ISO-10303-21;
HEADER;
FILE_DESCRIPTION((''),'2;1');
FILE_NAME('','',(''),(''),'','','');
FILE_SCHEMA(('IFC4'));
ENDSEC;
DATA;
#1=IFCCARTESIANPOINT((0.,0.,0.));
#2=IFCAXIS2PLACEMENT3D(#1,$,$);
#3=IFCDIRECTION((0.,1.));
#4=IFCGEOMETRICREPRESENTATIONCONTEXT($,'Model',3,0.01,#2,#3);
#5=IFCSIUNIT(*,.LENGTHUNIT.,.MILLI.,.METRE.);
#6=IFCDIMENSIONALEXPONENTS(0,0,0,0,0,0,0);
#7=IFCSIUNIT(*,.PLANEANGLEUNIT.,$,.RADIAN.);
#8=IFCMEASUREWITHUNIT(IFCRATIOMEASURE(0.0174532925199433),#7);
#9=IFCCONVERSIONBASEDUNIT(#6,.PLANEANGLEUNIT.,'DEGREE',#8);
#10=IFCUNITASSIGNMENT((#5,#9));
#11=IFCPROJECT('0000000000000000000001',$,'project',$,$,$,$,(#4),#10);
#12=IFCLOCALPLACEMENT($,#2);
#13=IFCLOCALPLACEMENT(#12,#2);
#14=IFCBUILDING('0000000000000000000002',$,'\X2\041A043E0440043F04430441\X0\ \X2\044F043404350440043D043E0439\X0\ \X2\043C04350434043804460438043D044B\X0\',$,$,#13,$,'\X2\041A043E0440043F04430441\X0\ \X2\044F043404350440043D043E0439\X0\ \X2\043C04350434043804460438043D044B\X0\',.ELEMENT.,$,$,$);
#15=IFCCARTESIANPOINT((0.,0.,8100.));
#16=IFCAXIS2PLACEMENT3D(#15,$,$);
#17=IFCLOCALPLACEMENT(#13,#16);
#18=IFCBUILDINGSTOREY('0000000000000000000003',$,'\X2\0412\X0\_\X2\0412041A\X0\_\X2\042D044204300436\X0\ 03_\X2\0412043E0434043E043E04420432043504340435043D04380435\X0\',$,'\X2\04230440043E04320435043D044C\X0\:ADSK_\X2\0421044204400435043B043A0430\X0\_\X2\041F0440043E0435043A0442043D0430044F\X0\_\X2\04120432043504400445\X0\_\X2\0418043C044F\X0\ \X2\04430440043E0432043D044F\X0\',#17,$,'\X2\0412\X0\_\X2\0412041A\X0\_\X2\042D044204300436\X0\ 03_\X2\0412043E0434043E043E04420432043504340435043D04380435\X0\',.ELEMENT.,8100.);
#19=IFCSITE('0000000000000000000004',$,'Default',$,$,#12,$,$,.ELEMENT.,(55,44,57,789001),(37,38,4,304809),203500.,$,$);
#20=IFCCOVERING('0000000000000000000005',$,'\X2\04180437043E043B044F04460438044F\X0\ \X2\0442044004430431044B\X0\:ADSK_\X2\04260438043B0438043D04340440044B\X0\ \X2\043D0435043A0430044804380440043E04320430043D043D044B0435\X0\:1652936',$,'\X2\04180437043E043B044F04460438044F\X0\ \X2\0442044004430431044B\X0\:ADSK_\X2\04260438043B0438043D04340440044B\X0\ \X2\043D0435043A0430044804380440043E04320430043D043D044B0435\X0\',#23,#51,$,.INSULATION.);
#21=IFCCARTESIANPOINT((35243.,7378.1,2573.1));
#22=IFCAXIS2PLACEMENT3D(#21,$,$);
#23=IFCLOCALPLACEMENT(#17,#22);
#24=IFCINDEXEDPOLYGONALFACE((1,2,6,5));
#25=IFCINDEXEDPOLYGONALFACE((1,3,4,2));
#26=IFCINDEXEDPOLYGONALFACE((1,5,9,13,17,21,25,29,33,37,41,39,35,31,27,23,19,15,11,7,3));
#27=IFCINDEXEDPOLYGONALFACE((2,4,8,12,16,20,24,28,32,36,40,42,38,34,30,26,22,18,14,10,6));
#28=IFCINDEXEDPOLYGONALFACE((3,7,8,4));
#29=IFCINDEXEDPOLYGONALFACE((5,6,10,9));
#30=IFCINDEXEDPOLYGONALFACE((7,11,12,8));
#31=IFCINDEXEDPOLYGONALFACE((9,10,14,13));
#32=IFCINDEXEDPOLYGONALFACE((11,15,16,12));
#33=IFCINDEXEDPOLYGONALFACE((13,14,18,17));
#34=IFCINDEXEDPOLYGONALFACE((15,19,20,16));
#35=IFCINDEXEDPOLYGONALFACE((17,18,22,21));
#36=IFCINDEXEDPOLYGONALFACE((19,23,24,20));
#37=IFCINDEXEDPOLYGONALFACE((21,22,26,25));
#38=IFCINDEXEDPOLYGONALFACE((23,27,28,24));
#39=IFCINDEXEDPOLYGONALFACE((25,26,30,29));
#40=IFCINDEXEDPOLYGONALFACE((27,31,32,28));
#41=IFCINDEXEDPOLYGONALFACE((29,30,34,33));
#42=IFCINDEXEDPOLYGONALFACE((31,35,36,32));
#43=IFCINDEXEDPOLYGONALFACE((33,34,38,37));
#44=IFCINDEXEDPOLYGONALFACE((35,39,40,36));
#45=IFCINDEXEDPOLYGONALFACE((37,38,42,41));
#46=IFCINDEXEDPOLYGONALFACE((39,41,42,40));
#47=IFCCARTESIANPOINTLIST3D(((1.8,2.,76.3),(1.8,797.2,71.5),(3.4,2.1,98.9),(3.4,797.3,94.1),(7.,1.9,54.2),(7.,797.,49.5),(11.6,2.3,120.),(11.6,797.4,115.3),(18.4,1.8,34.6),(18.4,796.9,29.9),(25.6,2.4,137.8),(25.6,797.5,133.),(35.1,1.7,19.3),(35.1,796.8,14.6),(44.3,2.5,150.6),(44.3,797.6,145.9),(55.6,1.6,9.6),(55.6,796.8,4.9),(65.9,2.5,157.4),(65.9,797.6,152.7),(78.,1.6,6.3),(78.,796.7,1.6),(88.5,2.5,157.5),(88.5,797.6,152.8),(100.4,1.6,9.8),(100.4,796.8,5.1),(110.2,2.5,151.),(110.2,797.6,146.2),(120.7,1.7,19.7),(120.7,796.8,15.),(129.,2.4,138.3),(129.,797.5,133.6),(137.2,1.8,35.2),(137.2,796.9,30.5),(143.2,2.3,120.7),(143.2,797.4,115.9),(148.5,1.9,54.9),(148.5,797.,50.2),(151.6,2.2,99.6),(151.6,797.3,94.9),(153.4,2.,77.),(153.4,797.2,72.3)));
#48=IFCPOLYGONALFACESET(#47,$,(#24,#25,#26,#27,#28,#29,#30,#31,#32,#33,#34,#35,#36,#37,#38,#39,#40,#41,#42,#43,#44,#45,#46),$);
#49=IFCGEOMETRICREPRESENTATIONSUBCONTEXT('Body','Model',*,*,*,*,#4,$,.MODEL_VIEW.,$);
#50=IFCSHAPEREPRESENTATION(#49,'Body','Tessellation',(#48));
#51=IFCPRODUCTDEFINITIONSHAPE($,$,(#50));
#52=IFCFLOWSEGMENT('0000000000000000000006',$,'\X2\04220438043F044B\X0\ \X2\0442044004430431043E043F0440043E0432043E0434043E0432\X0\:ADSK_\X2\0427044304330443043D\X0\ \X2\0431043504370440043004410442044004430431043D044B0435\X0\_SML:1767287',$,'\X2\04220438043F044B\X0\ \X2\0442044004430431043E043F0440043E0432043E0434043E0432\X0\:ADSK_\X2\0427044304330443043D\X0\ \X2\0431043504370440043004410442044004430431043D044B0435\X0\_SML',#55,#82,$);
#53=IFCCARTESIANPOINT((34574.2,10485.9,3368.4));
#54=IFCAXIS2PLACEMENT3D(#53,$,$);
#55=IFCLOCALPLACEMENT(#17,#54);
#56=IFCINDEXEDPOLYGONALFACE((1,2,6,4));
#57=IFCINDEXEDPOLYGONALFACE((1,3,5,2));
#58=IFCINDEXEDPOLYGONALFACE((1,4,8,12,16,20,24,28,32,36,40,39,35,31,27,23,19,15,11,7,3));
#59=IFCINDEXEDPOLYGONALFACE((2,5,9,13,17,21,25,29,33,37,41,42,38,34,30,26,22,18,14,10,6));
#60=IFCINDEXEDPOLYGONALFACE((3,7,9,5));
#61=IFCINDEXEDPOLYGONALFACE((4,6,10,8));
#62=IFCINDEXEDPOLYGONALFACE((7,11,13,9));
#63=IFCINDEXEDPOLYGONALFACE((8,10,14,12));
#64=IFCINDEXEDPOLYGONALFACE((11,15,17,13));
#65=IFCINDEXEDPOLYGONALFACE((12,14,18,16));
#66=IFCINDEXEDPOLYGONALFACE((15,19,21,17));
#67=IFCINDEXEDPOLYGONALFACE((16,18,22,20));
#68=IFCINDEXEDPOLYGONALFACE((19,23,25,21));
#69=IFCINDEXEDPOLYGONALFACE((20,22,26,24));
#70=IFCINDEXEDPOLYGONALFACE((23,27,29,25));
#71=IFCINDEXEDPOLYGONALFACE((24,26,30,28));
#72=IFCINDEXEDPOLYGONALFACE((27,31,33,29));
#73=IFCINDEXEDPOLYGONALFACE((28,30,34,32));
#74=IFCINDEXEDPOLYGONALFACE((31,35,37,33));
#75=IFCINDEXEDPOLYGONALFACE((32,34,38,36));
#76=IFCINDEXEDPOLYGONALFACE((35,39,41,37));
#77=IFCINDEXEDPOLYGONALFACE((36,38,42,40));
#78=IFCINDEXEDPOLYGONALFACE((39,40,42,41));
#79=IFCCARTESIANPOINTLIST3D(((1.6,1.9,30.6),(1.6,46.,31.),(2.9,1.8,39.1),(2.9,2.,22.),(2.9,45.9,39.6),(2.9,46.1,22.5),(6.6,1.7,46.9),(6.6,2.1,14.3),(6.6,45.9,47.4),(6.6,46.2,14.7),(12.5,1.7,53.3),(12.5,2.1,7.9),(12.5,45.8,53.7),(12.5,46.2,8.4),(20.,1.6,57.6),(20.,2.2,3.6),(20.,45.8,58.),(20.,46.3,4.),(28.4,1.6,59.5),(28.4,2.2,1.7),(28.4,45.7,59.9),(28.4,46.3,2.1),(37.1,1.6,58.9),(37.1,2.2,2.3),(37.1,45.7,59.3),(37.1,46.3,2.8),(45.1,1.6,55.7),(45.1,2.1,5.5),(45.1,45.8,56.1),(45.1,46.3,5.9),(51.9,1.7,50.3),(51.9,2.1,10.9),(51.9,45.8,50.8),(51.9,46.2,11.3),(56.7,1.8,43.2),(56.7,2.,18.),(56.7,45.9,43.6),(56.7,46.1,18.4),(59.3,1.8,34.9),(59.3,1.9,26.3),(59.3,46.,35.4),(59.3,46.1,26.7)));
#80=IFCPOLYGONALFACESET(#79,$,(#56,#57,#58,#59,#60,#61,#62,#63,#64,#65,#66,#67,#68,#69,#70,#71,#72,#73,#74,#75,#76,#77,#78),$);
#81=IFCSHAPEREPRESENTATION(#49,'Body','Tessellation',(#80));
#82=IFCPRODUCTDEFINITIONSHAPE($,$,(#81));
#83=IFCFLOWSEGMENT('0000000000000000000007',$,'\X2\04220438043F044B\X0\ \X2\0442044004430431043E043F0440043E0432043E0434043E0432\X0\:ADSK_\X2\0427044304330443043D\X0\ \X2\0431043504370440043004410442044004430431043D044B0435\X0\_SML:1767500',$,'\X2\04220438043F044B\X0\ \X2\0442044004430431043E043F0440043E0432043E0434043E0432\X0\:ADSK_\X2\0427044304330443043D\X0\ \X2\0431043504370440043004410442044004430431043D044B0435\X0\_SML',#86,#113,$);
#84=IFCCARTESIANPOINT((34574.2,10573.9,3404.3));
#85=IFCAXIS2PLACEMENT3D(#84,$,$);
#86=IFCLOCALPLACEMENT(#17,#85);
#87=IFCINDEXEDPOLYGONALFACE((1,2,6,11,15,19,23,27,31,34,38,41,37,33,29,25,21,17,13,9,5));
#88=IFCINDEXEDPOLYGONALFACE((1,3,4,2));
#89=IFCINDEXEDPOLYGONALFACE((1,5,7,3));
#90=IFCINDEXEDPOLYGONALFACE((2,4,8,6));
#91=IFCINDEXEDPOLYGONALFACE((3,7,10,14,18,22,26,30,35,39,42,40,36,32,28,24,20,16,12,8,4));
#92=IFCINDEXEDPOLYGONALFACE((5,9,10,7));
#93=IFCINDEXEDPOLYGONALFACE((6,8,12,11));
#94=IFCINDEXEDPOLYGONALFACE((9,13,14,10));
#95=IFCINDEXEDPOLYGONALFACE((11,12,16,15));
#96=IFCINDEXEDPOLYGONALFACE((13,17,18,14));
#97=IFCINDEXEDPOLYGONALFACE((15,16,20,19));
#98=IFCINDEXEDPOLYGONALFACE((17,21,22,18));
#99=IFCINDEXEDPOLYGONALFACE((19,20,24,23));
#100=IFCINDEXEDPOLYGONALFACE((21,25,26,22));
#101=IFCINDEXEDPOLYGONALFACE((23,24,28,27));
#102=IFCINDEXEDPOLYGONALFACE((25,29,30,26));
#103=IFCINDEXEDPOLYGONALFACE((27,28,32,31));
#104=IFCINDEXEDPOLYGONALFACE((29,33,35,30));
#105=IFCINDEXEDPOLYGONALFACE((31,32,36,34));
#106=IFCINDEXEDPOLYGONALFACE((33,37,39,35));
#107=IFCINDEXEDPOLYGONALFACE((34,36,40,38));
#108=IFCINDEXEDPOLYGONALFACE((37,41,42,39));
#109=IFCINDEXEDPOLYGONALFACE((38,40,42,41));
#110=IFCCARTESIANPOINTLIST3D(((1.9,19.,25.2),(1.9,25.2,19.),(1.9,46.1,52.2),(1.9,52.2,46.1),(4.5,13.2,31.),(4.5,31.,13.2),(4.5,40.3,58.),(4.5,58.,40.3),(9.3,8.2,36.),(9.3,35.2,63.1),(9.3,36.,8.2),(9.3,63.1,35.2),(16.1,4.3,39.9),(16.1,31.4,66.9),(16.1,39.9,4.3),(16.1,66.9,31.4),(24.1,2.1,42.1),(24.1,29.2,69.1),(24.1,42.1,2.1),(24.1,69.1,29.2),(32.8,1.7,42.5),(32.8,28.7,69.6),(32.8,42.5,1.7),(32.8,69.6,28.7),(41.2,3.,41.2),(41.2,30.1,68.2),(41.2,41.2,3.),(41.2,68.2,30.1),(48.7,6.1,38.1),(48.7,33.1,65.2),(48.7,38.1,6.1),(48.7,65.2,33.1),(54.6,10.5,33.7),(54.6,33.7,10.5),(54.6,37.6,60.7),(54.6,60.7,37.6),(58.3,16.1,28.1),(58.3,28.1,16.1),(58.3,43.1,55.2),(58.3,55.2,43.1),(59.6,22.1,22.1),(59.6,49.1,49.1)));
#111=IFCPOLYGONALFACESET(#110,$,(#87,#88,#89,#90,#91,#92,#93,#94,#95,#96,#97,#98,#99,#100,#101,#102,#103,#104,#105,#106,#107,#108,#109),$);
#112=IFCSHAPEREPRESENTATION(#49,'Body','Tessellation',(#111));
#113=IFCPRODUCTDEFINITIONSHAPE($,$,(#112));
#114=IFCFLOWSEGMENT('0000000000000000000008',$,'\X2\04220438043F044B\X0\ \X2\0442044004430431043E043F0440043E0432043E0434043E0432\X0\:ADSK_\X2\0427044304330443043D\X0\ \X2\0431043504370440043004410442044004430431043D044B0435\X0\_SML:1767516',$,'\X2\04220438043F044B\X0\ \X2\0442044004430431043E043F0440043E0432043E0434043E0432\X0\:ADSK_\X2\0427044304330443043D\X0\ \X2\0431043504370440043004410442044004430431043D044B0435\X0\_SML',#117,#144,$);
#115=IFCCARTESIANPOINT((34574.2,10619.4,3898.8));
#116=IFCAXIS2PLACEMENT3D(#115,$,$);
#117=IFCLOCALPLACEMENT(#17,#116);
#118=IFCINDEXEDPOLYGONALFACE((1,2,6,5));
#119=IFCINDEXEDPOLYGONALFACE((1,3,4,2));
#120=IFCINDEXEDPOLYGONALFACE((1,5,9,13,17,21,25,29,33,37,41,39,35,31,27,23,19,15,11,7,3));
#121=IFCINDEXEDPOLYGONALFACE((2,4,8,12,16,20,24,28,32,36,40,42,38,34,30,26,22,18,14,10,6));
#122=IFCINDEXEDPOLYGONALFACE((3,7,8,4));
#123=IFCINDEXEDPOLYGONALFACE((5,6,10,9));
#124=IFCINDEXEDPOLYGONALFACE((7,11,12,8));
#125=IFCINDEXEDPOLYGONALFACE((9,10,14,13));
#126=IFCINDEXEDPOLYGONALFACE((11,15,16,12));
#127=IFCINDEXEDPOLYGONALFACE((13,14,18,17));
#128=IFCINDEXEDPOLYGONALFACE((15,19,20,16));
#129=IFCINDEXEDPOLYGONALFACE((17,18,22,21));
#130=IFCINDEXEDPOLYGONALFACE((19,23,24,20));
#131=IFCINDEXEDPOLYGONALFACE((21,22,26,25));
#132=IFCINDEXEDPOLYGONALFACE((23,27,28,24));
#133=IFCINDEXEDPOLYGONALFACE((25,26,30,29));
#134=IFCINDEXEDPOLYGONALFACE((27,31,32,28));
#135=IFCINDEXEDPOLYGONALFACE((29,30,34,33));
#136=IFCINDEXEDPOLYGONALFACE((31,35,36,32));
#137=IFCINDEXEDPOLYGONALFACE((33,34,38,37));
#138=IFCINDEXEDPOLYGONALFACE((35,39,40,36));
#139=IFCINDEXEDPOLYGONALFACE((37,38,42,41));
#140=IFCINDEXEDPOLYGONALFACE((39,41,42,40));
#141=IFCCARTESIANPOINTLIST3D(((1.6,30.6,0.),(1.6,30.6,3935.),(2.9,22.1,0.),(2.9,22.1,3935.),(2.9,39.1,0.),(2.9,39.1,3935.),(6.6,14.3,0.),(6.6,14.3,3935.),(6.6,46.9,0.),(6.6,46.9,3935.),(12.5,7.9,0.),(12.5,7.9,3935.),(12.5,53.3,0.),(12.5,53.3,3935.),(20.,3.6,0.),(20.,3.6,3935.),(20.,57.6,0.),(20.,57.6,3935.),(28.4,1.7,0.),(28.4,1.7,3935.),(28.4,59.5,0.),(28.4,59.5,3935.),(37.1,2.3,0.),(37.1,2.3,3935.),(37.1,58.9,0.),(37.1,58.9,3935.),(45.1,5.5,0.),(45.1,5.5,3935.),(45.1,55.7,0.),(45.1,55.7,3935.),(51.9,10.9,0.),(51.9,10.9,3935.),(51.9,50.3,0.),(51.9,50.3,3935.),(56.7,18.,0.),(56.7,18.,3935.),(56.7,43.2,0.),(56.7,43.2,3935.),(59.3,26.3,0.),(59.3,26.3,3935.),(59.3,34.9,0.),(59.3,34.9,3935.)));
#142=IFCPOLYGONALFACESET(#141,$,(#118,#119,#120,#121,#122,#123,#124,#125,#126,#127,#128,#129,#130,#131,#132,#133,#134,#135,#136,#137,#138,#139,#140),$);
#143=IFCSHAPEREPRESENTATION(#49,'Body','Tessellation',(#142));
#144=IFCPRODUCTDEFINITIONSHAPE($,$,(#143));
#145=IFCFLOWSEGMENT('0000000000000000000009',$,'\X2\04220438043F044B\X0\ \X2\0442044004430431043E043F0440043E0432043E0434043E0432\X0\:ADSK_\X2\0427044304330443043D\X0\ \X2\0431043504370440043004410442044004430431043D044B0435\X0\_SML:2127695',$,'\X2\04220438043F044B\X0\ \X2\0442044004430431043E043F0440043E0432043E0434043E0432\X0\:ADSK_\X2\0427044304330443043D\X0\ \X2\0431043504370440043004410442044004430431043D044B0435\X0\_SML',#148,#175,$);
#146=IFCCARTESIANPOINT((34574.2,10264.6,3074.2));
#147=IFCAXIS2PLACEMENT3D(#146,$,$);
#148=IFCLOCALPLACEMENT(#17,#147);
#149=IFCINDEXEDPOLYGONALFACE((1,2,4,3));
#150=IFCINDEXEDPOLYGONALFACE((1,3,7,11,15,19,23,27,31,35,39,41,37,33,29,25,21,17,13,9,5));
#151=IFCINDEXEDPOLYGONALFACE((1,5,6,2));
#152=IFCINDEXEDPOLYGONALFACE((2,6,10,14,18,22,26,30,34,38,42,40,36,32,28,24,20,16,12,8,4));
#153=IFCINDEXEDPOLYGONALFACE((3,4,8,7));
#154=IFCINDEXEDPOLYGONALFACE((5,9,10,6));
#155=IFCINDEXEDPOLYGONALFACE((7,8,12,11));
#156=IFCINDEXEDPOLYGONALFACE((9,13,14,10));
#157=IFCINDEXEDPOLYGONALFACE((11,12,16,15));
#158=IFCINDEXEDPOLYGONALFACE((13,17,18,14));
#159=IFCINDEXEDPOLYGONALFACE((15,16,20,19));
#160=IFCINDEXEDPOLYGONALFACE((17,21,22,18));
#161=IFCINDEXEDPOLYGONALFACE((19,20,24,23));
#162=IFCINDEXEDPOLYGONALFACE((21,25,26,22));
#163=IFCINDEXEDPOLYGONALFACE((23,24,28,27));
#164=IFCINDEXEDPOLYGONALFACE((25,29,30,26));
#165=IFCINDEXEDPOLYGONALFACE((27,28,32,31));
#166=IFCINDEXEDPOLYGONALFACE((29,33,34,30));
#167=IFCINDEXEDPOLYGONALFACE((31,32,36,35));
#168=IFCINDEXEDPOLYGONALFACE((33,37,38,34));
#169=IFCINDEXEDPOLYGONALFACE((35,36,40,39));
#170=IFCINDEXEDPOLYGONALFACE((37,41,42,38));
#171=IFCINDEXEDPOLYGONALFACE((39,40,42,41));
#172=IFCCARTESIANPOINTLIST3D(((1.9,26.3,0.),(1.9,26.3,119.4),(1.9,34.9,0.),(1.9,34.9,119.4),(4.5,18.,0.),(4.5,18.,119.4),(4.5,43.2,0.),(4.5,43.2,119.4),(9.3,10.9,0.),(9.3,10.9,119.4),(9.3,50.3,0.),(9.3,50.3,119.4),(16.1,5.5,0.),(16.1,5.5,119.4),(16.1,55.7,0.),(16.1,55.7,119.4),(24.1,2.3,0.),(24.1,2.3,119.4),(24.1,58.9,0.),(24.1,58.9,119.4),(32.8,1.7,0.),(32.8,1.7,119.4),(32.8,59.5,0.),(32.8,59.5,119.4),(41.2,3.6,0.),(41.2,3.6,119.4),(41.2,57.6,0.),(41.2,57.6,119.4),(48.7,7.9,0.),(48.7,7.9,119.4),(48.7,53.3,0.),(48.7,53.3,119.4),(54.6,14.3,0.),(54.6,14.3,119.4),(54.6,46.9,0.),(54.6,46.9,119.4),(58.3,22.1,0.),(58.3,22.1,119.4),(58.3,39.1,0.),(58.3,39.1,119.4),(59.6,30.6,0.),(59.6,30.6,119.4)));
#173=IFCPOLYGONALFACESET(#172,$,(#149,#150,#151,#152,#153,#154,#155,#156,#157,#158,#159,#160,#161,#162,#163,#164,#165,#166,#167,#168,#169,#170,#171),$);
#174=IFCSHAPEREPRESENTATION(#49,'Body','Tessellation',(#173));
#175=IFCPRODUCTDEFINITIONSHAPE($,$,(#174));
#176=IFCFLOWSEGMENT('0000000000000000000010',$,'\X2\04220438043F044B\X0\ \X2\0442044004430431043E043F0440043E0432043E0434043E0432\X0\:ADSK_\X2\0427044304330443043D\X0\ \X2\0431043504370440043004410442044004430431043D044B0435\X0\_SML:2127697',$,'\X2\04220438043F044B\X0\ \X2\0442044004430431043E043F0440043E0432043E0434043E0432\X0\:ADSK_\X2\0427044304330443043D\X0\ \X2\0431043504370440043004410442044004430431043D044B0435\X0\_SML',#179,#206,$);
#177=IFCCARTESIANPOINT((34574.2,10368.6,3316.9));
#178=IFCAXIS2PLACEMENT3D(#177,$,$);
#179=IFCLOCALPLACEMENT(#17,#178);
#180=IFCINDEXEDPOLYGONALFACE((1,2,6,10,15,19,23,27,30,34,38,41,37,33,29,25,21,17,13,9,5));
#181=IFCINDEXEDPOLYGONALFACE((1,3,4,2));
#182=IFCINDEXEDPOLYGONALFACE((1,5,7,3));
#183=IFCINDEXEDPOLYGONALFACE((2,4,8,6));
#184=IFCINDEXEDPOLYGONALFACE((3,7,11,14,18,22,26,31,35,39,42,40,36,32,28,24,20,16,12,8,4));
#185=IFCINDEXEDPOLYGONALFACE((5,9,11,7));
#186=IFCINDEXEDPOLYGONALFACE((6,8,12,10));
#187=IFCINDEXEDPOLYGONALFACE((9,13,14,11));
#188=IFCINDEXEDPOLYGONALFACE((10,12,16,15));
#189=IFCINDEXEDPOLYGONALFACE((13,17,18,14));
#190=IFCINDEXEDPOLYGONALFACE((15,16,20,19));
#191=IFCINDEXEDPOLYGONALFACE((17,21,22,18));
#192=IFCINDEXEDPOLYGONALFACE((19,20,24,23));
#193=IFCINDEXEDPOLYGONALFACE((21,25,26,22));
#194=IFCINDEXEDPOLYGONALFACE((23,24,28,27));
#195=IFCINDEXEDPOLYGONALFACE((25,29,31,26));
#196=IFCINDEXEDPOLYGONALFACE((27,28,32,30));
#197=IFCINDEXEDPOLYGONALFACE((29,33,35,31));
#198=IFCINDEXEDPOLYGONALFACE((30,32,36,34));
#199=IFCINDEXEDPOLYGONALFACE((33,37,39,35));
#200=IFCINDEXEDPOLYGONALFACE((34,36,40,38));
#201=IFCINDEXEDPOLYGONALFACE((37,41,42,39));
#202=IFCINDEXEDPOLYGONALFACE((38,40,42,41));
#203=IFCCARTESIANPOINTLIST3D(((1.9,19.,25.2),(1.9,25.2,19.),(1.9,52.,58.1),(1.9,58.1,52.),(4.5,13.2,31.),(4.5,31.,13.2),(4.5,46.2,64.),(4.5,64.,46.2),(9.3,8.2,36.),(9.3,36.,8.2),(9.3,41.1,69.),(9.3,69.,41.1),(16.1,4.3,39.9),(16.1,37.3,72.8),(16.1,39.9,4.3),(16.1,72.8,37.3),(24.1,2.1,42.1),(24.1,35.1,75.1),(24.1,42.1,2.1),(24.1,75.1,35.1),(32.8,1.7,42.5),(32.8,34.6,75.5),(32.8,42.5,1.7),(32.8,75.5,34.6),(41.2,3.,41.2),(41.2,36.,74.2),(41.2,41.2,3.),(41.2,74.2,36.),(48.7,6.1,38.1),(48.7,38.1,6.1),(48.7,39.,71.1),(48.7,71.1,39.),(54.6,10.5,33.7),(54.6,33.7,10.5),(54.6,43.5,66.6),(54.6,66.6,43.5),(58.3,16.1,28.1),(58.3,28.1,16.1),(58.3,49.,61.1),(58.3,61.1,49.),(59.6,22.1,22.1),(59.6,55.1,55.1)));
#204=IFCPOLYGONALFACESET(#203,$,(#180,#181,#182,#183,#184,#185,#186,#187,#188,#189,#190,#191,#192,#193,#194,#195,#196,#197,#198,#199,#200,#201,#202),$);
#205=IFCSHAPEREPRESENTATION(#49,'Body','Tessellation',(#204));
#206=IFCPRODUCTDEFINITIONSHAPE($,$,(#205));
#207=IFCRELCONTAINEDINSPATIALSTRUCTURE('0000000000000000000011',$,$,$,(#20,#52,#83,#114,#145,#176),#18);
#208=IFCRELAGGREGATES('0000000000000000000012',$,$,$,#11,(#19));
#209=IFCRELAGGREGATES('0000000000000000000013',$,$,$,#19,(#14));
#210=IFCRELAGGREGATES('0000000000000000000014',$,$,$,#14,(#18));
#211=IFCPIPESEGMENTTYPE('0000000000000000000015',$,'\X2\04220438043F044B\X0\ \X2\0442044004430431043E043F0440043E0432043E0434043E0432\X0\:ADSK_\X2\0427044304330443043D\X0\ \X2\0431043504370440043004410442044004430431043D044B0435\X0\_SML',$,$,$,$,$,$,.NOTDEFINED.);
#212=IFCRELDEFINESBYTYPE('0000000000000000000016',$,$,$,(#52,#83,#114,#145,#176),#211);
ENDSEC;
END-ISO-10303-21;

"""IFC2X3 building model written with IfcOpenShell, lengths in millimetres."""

from ifc_helpers import new_model, entity, si_unit, converted_unit, direction, frame, origin, origin_2d_with_axis, place, context, subcontext, project, spatial, circle, extrude, type_object, element, save


model = new_model("IFC2X3")

# Units and contexts
model_context = context("Model", 3, precision=0.01, world=origin(), true_north=direction((0.0, 1.0)))
body_context = subcontext(model_context, "Body", "Model", "MODEL_VIEW")
ifc_project = project(units=[si_unit("LENGTHUNIT", "METRE", prefix="MILLI"), converted_unit("PLANEANGLEUNIT", "DEGREE", entity("IfcRatioMeasure", 0.0174532925199433), si_unit("PLANEANGLEUNIT", "RADIAN"), dimensions=[0, 0, 0, 0, 0, 0, 0])], contexts=[model_context])

# Site, building, storey
site_placement = place(None, origin())
site = spatial("IfcSite", under=ifc_project, at=site_placement, Name="Default", CompositionType="ELEMENT", RefLatitude=(55, 44, 57, 789001), RefLongitude=(37, 38, 4, 304809), RefElevation=203500.0)
building_placement = place(site_placement, origin())
building = spatial("IfcBuilding", under=site, at=building_placement, Name="Корпус ядерной медицины", LongName="Корпус ядерной медицины", CompositionType="ELEMENT")
storey_placement = place(building_placement, frame((0.0, 0.0, 8100.0)))
storey = spatial("IfcBuildingStorey", under=building, at=storey_placement, Name="В_ВК_Этаж 03_Водоотведение", ObjectType="Уровень:ADSK_Стрелка_Проектная_Вверх_Имя уровня", LongName="В_ВК_Этаж 03_Водоотведение", CompositionType="ELEMENT", Elevation=8100.0)

# Covering
covering_placement = place(storey_placement, frame((35243.0, 7378.1, 2573.1)))
element("IfcCovering", 1, at=covering_placement, inside=storey, Name="Изоляция трубы:ADSK_Цилиндры некашированные:1652936", ObjectType="Изоляция трубы:ADSK_Цилиндры некашированные", PredefinedType="INSULATION", context=body_context, shape_type="SweptSolid", body=[
    extrude(circle(Radius=76.0, at=origin_2d_with_axis()), frame((77.6, 797.2, 77.6), z_axis=(0.000003, -0.999982, 0.005956), x_axis=(0.005, -0.005956, -0.99997)), (0.0, 0.0, 1.0), 795.2),
])

# Flow segments
pipe_segment_type_1 = type_object("IfcPipeSegmentType", Name="Типы трубопроводов:ADSK_Чугун безраструбные_SML", PredefinedType="NOTDEFINED")
flow_segment_1_placement = place(storey_placement, frame((34574.2, 10485.9, 3368.4)))
element("IfcFlowSegment", 2, at=flow_segment_1_placement, inside=storey, type_object=pipe_segment_type_1, Name="Типы трубопроводов:ADSK_Чугун безраструбные_SML:1767287", ObjectType="Типы трубопроводов:ADSK_Чугун безраструбные_SML", context=body_context, shape_type="SweptSolid", body=[
    extrude(circle(Radius=29.0, at=origin_2d_with_axis()), frame((30.6, 1.9, 30.6), z_axis=(0.0, 0.99995, 0.01), x_axis=(-1.0, 0.0, 0.0)), (0.0, 0.0, 1.0), 44.1),
])
flow_segment_2_placement = place(storey_placement, frame((34574.2, 10573.9, 3404.3)))
element("IfcFlowSegment", 3, at=flow_segment_2_placement, inside=storey, type_object=pipe_segment_type_1, Name="Типы трубопроводов:ADSK_Чугун безраструбные_SML:1767500", ObjectType="Типы трубопроводов:ADSK_Чугун безраструбные_SML", context=body_context, shape_type="SweptSolid", body=[
    extrude(circle(Radius=29.0, at=origin_2d_with_axis()), frame((30.6, 22.1, 22.1), z_axis=(0.0, 0.707107, 0.707107), x_axis=(1.0, 0.0, 0.0)), (0.0, 0.0, 1.0), 38.3),
])
flow_segment_3_placement = place(storey_placement, frame((34574.2, 10619.4, 3898.8)))
element("IfcFlowSegment", 4, at=flow_segment_3_placement, inside=storey, type_object=pipe_segment_type_1, Name="Типы трубопроводов:ADSK_Чугун безраструбные_SML:1767516", ObjectType="Типы трубопроводов:ADSK_Чугун безраструбные_SML", context=body_context, shape_type="SweptSolid", body=[
    extrude(circle(Radius=29.0, at=origin_2d_with_axis()), frame((30.6, 30.6, 0.0), z_axis=(0.0, 0.0, 1.0), x_axis=(-1.0, 0.0, 0.0)), (0.0, 0.0, 1.0), 3935.0),
])
flow_segment_4_placement = place(storey_placement, frame((34574.2, 10264.6, 3074.2)))
element("IfcFlowSegment", 5, at=flow_segment_4_placement, inside=storey, type_object=pipe_segment_type_1, Name="Типы трубопроводов:ADSK_Чугун безраструбные_SML:2127695", ObjectType="Типы трубопроводов:ADSK_Чугун безраструбные_SML", context=body_context, shape_type="SweptSolid", body=[
    extrude(circle(Radius=29.0, at=origin_2d_with_axis()), frame((30.6, 30.6, 0.0)), (0.0, 0.0, 1.0), 119.4),
])
flow_segment_5_placement = place(storey_placement, frame((34574.2, 10368.6, 3316.9)))
element("IfcFlowSegment", 6, at=flow_segment_5_placement, inside=storey, type_object=pipe_segment_type_1, Name="Типы трубопроводов:ADSK_Чугун безраструбные_SML:2127697", ObjectType="Типы трубопроводов:ADSK_Чугун безраструбные_SML", context=body_context, shape_type="SweptSolid", body=[
    extrude(circle(Radius=29.0, at=origin_2d_with_axis()), frame((30.6, 22.1, 22.1), z_axis=(0.0, 0.707107, 0.707107), x_axis=(1.0, 0.0, 0.0)), (0.0, 0.0, 1.0), 46.6),
])

save(model, "model.ifc")
